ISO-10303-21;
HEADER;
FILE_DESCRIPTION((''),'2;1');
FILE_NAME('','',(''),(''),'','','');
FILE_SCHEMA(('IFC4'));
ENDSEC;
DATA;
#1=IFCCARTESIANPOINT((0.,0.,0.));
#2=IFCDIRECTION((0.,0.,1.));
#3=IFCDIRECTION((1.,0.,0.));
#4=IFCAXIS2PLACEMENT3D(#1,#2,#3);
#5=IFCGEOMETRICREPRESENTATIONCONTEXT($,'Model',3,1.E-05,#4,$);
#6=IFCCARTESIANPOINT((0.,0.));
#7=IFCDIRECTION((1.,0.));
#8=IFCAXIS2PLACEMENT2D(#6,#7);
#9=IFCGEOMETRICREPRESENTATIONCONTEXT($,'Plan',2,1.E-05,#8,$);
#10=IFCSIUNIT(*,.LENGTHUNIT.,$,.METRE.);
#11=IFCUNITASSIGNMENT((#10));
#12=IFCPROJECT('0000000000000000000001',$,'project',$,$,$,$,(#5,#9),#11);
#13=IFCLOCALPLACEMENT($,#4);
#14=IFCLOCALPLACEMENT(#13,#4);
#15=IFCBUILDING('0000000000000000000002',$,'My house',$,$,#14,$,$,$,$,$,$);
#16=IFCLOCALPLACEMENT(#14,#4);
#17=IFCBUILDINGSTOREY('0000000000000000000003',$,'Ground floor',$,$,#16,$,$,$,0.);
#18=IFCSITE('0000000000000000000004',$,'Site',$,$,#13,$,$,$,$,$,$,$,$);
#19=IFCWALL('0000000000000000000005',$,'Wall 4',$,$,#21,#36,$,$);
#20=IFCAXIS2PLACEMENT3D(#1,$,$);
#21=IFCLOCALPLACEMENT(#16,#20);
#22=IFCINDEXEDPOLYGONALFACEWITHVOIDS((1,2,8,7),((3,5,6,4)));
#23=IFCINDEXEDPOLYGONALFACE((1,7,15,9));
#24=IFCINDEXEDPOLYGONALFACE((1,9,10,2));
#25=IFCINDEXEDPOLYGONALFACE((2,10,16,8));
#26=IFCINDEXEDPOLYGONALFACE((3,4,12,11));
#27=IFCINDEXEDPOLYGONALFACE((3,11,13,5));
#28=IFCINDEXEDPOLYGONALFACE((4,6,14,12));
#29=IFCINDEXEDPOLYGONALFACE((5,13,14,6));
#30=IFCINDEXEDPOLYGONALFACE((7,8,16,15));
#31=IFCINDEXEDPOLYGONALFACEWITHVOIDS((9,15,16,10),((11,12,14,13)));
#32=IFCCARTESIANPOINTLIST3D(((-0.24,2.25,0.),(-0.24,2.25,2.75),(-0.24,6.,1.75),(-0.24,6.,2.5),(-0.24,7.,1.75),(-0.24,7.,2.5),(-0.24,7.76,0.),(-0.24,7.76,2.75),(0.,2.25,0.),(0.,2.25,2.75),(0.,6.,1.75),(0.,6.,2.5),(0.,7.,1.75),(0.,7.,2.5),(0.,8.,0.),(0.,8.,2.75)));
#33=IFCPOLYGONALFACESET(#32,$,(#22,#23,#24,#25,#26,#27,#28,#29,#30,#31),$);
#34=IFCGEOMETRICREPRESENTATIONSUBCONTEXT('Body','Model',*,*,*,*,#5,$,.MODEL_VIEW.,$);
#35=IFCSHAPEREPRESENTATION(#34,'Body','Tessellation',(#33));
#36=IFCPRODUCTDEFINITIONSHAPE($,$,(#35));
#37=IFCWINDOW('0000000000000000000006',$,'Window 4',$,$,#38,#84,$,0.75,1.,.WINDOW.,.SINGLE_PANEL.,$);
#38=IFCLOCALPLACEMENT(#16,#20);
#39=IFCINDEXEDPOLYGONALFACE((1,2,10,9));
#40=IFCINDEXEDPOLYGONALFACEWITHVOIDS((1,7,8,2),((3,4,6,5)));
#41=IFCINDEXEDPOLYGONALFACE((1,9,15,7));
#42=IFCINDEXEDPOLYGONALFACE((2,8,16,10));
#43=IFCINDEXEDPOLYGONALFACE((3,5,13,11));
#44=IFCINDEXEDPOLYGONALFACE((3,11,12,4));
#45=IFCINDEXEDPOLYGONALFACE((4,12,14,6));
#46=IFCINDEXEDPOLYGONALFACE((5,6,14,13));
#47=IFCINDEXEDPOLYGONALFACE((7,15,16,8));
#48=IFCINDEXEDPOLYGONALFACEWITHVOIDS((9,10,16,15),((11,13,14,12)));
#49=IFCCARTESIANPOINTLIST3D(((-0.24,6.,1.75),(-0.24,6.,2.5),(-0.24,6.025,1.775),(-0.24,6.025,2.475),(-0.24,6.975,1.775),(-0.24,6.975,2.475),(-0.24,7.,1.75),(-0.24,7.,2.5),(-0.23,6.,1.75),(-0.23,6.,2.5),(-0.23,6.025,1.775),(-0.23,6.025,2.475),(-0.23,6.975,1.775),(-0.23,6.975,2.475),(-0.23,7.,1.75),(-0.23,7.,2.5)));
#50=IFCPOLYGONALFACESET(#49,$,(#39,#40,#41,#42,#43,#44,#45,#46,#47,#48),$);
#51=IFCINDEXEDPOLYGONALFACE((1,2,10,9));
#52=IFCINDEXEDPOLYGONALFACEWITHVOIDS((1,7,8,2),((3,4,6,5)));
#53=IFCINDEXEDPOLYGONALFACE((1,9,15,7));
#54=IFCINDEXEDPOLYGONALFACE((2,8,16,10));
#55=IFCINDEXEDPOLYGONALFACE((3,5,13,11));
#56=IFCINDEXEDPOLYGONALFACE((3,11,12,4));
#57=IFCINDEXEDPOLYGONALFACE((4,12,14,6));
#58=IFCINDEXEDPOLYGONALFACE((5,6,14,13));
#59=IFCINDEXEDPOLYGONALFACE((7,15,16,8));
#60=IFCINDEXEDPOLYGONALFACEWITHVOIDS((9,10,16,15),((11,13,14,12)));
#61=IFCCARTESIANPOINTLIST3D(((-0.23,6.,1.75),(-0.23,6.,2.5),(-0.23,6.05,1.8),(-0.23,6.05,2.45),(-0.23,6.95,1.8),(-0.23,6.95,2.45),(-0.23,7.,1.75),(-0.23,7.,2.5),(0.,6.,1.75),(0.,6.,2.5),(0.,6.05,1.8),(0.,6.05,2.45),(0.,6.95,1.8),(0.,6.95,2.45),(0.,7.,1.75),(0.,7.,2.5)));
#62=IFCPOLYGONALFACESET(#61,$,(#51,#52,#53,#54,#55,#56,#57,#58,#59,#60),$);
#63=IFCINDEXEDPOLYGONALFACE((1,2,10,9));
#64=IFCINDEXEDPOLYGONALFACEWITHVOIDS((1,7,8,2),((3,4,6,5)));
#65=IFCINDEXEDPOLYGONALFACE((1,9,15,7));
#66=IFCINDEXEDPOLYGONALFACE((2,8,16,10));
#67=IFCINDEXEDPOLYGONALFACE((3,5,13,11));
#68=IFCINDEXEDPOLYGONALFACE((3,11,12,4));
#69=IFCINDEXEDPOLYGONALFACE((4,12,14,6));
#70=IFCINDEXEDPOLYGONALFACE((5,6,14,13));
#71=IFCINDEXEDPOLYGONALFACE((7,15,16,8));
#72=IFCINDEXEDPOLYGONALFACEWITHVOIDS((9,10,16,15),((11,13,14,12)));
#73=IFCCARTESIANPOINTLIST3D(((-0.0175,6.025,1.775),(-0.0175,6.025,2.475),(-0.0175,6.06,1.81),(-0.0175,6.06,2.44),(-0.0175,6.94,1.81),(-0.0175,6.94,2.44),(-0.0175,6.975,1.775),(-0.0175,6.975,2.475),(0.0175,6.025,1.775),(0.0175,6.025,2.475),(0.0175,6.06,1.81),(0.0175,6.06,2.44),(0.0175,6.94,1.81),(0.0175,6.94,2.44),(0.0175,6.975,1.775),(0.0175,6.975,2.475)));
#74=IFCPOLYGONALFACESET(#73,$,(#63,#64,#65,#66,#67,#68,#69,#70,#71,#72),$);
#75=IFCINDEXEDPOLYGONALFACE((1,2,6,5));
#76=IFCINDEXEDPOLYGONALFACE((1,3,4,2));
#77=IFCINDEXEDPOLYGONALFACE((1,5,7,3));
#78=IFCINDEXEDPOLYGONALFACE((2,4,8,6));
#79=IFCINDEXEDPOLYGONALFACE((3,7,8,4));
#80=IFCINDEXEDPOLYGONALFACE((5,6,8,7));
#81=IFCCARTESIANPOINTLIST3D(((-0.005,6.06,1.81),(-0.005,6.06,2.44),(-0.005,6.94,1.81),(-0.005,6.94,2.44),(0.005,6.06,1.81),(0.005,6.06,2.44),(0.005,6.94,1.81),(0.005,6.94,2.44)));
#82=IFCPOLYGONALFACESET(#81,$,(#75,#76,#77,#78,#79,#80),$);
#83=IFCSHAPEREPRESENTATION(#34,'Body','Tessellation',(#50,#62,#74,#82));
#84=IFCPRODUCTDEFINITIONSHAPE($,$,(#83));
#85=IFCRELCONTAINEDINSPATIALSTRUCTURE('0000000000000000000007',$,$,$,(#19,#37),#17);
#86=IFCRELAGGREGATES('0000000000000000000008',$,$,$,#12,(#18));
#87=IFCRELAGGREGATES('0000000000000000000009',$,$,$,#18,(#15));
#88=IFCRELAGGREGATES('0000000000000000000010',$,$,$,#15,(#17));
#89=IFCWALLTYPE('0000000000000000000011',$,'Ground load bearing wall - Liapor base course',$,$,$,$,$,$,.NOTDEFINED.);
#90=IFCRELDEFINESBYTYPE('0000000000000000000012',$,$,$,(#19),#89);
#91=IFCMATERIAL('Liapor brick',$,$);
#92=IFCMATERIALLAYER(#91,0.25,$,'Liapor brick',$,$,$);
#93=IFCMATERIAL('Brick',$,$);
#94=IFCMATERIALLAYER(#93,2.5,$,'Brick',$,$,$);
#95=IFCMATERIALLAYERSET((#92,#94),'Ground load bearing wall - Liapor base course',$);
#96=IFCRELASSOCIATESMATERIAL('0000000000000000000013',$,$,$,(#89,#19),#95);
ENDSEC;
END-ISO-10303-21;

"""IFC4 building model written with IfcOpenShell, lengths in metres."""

from ifc_helpers import new_model, entity, si_unit, frame, origin_with_axes, origin_2d_with_axis, place, context, subcontext, project, spatial, line, indexed_curve, outline, extrude, shape, source, transform, mapped, material, layer, layer_set, layer_usage, type_object, element, fill, save


model = new_model("IFC4")

# Units and contexts
model_context = context("Model", 3, precision=1e-05, world=origin_with_axes())
plan_context = context("Plan", 2, precision=1e-05, world=origin_2d_with_axis())
body_context_1 = subcontext(model_context, "Body", "Model", "MODEL_VIEW")
body_context_2 = subcontext(plan_context, "Body", "Plan", "PLAN_VIEW")
ifc_project = project(units=[si_unit("LENGTHUNIT", "METRE")], contexts=[model_context, plan_context])

# Site, building, storey
site_placement = place(None, origin_with_axes())
site = spatial("IfcSite", under=ifc_project, at=site_placement, Name="Site")
building_placement = place(site_placement, origin_with_axes())
building = spatial("IfcBuilding", under=site, at=building_placement, Name="My house")
storey_placement = place(building_placement, origin_with_axes())
storey = spatial("IfcBuildingStorey", under=building, at=storey_placement, Name="Ground floor", Elevation=0.0)

# Wall, opening, window
ifc_material_1 = material(Name="Liapor brick")
ifc_layer_1 = layer(ifc_material_1, 0.25, Name="Liapor brick")
ifc_material_2 = material(Name="Brick")
ifc_layer_2 = layer(ifc_material_2, 2.5, Name="Brick")
ifc_layer_set_1 = layer_set([ifc_layer_1, ifc_layer_2], Name="Ground load bearing wall - Liapor base course")
wall_type_1 = type_object("IfcWallType", Name="Ground load bearing wall - Liapor base course", PredefinedType="NOTDEFINED", material=ifc_layer_set_1)
ifc_layer_usage_1 = layer_usage(ifc_layer_set_1, "AXIS3", "POSITIVE", 0.0)
shared_shape_1 = source(origin_with_axes(), body_context_1, "Body", "SweptSolid", [
    extrude(outline(indexed_curve([(0.0, 0.0), (0.24, 0.24), (5.75, 0.24), (5.75, 0.0)], segments=[line(1, 2, 3, 4, 1)])), origin_with_axes(), (0.0, 0.0, 1.0), 2.75),
])
wall_1_placement = place(storey_placement, frame((0.0, 8.0, 0.0), z_axis=(0.0, 0.0, 1.0), x_axis=(0.0, 1.0, 0.0)))
wall_1 = element("IfcWall", 1, at=wall_1_placement, inside=storey, type_object=wall_type_1, material=ifc_layer_usage_1, Name="Wall 4", context=body_context_1, shape_type="MappedRepresentation", body=[
    mapped(shared_shape_1, transform((0.0, 0.0, 0.0), x_axis=(-1.0, 0.0, 0.0), y_axis=(0.0, 1.0, 0.0), z_axis=(0.0, 0.0, 1.0), scale=1.0)),
])
shared_shape_2 = source(origin_with_axes(), body_context_1, "Body", "SweptSolid", [
    extrude(outline(indexed_curve([(0.0, 0.0), (0.0, 0.34), (1.0, 0.34), (1.0, 0.0), (0.0, 0.0)], self_intersect=False)), frame((0.0, -0.05, 0.0), z_axis=(0.0, 0.0, 1.0), x_axis=(1.0, 0.0, 0.0)), (0.0, 0.0, 1.0), 0.75),
])
opening_1_placement = place(wall_1_placement, frame((-1.0, 0.0, 1.75), z_axis=(0.0, 0.0, 1.0), x_axis=(1.0, 0.0, 0.0)))
opening_1 = element("IfcOpeningElement", 2, at=opening_1_placement, cuts=wall_1, PredefinedType="OPENING", context=body_context_1, shape_type="MappedRepresentation", body=[
    mapped(shared_shape_2, transform((0.0, 0.0, 0.0), x_axis=(-1.0, 0.0, 0.0), y_axis=(0.0, 1.0, 0.0), z_axis=(0.0, 0.0, 1.0), scale=1.0)),
])
shared_shape_3 = source(origin_with_axes(), body_context_1, "Body", "SweptSolid", [
    extrude(outline(indexed_curve([(0.0, 0.0), (1.0, 0.0), (1.0, 0.75), (0.0, 0.75)], segments=[line(1, 2, 3, 4, 1)]), holes=[indexed_curve([(0.025, 0.025), (0.975, 0.025), (0.975, 0.725), (0.025, 0.725)], segments=[line(1, 2, 3, 4, 1)])]), frame((0.0, 0.23, 0.0), z_axis=(0.0, -1.0, 0.0), x_axis=(1.0, 0.0, 0.0)), (0.0, 0.0, -1.0), 0.01),
    extrude(outline(indexed_curve([(0.0, 0.0), (1.0, 0.0), (1.0, 0.75), (0.0, 0.75)], segments=[line(1, 2, 3, 4, 1)]), holes=[indexed_curve([(0.05, 0.05), (0.95, 0.05), (0.95, 0.7), (0.05, 0.7)], segments=[line(1, 2, 3, 4, 1)])]), frame((0.0, 0.0, 0.0), z_axis=(0.0, -1.0, 0.0), x_axis=(1.0, 0.0, 0.0)), (0.0, 0.0, -1.0), 0.23),
    extrude(outline(indexed_curve([(0.0, 0.0), (0.95, 0.0), (0.95, 0.7), (0.0, 0.7)], segments=[line(1, 2, 3, 4, 1)]), holes=[indexed_curve([(0.035, 0.035), (0.915, 0.035), (0.915, 0.665), (0.035, 0.665)], segments=[line(1, 2, 3, 4, 1)])]), frame((0.025, -0.0175, 0.025), z_axis=(0.0, -1.0, 0.0), x_axis=(1.0, 0.0, 0.0)), (0.0, 0.0, -1.0), 0.035),
    extrude(outline(indexed_curve([(0.035, 0.035), (0.915, 0.035), (0.915, 0.665), (0.035, 0.665)], segments=[line(1, 2, 3, 4, 1)])), frame((0.025, -0.005, 0.025), z_axis=(0.0, -1.0, 0.0), x_axis=(1.0, 0.0, 0.0)), (0.0, 0.0, -1.0), 0.01),
])
shared_shape_4 = source(origin_with_axes(), body_context_2, "Body", "Curve2D", [
    entity("IfcIndexedPolyCurve", entity("IfcCartesianPointList2D", [[0.05, 0.0], [0.95, 0.0]])),
    entity("IfcIndexedPolyCurve", entity("IfcCartesianPointList2D", [[0.0, 0.24], [0.025, 0.24], [0.025, 0.23], [0.05, 0.23], [0.05, 0.0], [0.0, 0.0]]), [entity("IfcLineIndex", [1, 2, 3, 4, 5, 6, 1])]),
    entity("IfcIndexedPolyCurve", entity("IfcCartesianPointList2D", [[1.0, 0.24], [0.975, 0.24], [0.975, 0.23], [0.95, 0.23], [0.95, 0.0], [1.0, 0.0]]), [entity("IfcLineIndex", [1, 2, 3, 4, 5, 6, 1])]),
    entity("IfcIndexedPolyCurve", entity("IfcCartesianPointList2D", [[0.025, -0.0175], [0.06, -0.0175], [0.06, 0.0175], [0.025, 0.0175]]), [entity("IfcLineIndex", [1, 2, 3, 4, 1])]),
    entity("IfcIndexedPolyCurve", entity("IfcCartesianPointList2D", [[0.975, -0.0175], [0.94, -0.0175], [0.94, 0.0175], [0.975, 0.0175]]), [entity("IfcLineIndex", [1, 2, 3, 4, 1])]),
    entity("IfcIndexedPolyCurve", entity("IfcCartesianPointList2D", [[0.06, -0.0175], [0.94, -0.0175]])),
    entity("IfcIndexedPolyCurve", entity("IfcCartesianPointList2D", [[0.06, 0.0175], [0.94, 0.0175]])),
    entity("IfcIndexedPolyCurve", entity("IfcCartesianPointList2D", [[0.06, 0.0], [0.94, 0.0]])),
])
window_1_placement = place(opening_1_placement, frame((0.0, 0.0, 0.0), z_axis=(0.0, 0.0, 1.0), x_axis=(1.0, 0.0, 0.0)))
window_1 = element("IfcWindow", 3, at=window_1_placement, inside=storey, Name="Window 4", OverallHeight=0.75, OverallWidth=1.0, PartitioningType="SINGLE_PANEL", PredefinedType="WINDOW", shapes=[
    shape(body_context_1, "Body", "MappedRepresentation", [mapped(shared_shape_3, transform((0.0, 0.0, 0.0), x_axis=(-1.0, 0.0, 0.0), y_axis=(0.0, 1.0, 0.0), z_axis=(0.0, 0.0, 1.0), scale=1.0))]),
    shape(body_context_2, "Body", "MappedRepresentation", [mapped(shared_shape_4, transform((0.0, 0.0, 0.0), x_axis=(-1.0, 0.0, 0.0), y_axis=(0.0, 1.0, 0.0), z_axis=(0.0, 0.0, 1.0), scale=1.0))]),
])
fill(opening_1, window_1)

save(model, "model.ifc")
